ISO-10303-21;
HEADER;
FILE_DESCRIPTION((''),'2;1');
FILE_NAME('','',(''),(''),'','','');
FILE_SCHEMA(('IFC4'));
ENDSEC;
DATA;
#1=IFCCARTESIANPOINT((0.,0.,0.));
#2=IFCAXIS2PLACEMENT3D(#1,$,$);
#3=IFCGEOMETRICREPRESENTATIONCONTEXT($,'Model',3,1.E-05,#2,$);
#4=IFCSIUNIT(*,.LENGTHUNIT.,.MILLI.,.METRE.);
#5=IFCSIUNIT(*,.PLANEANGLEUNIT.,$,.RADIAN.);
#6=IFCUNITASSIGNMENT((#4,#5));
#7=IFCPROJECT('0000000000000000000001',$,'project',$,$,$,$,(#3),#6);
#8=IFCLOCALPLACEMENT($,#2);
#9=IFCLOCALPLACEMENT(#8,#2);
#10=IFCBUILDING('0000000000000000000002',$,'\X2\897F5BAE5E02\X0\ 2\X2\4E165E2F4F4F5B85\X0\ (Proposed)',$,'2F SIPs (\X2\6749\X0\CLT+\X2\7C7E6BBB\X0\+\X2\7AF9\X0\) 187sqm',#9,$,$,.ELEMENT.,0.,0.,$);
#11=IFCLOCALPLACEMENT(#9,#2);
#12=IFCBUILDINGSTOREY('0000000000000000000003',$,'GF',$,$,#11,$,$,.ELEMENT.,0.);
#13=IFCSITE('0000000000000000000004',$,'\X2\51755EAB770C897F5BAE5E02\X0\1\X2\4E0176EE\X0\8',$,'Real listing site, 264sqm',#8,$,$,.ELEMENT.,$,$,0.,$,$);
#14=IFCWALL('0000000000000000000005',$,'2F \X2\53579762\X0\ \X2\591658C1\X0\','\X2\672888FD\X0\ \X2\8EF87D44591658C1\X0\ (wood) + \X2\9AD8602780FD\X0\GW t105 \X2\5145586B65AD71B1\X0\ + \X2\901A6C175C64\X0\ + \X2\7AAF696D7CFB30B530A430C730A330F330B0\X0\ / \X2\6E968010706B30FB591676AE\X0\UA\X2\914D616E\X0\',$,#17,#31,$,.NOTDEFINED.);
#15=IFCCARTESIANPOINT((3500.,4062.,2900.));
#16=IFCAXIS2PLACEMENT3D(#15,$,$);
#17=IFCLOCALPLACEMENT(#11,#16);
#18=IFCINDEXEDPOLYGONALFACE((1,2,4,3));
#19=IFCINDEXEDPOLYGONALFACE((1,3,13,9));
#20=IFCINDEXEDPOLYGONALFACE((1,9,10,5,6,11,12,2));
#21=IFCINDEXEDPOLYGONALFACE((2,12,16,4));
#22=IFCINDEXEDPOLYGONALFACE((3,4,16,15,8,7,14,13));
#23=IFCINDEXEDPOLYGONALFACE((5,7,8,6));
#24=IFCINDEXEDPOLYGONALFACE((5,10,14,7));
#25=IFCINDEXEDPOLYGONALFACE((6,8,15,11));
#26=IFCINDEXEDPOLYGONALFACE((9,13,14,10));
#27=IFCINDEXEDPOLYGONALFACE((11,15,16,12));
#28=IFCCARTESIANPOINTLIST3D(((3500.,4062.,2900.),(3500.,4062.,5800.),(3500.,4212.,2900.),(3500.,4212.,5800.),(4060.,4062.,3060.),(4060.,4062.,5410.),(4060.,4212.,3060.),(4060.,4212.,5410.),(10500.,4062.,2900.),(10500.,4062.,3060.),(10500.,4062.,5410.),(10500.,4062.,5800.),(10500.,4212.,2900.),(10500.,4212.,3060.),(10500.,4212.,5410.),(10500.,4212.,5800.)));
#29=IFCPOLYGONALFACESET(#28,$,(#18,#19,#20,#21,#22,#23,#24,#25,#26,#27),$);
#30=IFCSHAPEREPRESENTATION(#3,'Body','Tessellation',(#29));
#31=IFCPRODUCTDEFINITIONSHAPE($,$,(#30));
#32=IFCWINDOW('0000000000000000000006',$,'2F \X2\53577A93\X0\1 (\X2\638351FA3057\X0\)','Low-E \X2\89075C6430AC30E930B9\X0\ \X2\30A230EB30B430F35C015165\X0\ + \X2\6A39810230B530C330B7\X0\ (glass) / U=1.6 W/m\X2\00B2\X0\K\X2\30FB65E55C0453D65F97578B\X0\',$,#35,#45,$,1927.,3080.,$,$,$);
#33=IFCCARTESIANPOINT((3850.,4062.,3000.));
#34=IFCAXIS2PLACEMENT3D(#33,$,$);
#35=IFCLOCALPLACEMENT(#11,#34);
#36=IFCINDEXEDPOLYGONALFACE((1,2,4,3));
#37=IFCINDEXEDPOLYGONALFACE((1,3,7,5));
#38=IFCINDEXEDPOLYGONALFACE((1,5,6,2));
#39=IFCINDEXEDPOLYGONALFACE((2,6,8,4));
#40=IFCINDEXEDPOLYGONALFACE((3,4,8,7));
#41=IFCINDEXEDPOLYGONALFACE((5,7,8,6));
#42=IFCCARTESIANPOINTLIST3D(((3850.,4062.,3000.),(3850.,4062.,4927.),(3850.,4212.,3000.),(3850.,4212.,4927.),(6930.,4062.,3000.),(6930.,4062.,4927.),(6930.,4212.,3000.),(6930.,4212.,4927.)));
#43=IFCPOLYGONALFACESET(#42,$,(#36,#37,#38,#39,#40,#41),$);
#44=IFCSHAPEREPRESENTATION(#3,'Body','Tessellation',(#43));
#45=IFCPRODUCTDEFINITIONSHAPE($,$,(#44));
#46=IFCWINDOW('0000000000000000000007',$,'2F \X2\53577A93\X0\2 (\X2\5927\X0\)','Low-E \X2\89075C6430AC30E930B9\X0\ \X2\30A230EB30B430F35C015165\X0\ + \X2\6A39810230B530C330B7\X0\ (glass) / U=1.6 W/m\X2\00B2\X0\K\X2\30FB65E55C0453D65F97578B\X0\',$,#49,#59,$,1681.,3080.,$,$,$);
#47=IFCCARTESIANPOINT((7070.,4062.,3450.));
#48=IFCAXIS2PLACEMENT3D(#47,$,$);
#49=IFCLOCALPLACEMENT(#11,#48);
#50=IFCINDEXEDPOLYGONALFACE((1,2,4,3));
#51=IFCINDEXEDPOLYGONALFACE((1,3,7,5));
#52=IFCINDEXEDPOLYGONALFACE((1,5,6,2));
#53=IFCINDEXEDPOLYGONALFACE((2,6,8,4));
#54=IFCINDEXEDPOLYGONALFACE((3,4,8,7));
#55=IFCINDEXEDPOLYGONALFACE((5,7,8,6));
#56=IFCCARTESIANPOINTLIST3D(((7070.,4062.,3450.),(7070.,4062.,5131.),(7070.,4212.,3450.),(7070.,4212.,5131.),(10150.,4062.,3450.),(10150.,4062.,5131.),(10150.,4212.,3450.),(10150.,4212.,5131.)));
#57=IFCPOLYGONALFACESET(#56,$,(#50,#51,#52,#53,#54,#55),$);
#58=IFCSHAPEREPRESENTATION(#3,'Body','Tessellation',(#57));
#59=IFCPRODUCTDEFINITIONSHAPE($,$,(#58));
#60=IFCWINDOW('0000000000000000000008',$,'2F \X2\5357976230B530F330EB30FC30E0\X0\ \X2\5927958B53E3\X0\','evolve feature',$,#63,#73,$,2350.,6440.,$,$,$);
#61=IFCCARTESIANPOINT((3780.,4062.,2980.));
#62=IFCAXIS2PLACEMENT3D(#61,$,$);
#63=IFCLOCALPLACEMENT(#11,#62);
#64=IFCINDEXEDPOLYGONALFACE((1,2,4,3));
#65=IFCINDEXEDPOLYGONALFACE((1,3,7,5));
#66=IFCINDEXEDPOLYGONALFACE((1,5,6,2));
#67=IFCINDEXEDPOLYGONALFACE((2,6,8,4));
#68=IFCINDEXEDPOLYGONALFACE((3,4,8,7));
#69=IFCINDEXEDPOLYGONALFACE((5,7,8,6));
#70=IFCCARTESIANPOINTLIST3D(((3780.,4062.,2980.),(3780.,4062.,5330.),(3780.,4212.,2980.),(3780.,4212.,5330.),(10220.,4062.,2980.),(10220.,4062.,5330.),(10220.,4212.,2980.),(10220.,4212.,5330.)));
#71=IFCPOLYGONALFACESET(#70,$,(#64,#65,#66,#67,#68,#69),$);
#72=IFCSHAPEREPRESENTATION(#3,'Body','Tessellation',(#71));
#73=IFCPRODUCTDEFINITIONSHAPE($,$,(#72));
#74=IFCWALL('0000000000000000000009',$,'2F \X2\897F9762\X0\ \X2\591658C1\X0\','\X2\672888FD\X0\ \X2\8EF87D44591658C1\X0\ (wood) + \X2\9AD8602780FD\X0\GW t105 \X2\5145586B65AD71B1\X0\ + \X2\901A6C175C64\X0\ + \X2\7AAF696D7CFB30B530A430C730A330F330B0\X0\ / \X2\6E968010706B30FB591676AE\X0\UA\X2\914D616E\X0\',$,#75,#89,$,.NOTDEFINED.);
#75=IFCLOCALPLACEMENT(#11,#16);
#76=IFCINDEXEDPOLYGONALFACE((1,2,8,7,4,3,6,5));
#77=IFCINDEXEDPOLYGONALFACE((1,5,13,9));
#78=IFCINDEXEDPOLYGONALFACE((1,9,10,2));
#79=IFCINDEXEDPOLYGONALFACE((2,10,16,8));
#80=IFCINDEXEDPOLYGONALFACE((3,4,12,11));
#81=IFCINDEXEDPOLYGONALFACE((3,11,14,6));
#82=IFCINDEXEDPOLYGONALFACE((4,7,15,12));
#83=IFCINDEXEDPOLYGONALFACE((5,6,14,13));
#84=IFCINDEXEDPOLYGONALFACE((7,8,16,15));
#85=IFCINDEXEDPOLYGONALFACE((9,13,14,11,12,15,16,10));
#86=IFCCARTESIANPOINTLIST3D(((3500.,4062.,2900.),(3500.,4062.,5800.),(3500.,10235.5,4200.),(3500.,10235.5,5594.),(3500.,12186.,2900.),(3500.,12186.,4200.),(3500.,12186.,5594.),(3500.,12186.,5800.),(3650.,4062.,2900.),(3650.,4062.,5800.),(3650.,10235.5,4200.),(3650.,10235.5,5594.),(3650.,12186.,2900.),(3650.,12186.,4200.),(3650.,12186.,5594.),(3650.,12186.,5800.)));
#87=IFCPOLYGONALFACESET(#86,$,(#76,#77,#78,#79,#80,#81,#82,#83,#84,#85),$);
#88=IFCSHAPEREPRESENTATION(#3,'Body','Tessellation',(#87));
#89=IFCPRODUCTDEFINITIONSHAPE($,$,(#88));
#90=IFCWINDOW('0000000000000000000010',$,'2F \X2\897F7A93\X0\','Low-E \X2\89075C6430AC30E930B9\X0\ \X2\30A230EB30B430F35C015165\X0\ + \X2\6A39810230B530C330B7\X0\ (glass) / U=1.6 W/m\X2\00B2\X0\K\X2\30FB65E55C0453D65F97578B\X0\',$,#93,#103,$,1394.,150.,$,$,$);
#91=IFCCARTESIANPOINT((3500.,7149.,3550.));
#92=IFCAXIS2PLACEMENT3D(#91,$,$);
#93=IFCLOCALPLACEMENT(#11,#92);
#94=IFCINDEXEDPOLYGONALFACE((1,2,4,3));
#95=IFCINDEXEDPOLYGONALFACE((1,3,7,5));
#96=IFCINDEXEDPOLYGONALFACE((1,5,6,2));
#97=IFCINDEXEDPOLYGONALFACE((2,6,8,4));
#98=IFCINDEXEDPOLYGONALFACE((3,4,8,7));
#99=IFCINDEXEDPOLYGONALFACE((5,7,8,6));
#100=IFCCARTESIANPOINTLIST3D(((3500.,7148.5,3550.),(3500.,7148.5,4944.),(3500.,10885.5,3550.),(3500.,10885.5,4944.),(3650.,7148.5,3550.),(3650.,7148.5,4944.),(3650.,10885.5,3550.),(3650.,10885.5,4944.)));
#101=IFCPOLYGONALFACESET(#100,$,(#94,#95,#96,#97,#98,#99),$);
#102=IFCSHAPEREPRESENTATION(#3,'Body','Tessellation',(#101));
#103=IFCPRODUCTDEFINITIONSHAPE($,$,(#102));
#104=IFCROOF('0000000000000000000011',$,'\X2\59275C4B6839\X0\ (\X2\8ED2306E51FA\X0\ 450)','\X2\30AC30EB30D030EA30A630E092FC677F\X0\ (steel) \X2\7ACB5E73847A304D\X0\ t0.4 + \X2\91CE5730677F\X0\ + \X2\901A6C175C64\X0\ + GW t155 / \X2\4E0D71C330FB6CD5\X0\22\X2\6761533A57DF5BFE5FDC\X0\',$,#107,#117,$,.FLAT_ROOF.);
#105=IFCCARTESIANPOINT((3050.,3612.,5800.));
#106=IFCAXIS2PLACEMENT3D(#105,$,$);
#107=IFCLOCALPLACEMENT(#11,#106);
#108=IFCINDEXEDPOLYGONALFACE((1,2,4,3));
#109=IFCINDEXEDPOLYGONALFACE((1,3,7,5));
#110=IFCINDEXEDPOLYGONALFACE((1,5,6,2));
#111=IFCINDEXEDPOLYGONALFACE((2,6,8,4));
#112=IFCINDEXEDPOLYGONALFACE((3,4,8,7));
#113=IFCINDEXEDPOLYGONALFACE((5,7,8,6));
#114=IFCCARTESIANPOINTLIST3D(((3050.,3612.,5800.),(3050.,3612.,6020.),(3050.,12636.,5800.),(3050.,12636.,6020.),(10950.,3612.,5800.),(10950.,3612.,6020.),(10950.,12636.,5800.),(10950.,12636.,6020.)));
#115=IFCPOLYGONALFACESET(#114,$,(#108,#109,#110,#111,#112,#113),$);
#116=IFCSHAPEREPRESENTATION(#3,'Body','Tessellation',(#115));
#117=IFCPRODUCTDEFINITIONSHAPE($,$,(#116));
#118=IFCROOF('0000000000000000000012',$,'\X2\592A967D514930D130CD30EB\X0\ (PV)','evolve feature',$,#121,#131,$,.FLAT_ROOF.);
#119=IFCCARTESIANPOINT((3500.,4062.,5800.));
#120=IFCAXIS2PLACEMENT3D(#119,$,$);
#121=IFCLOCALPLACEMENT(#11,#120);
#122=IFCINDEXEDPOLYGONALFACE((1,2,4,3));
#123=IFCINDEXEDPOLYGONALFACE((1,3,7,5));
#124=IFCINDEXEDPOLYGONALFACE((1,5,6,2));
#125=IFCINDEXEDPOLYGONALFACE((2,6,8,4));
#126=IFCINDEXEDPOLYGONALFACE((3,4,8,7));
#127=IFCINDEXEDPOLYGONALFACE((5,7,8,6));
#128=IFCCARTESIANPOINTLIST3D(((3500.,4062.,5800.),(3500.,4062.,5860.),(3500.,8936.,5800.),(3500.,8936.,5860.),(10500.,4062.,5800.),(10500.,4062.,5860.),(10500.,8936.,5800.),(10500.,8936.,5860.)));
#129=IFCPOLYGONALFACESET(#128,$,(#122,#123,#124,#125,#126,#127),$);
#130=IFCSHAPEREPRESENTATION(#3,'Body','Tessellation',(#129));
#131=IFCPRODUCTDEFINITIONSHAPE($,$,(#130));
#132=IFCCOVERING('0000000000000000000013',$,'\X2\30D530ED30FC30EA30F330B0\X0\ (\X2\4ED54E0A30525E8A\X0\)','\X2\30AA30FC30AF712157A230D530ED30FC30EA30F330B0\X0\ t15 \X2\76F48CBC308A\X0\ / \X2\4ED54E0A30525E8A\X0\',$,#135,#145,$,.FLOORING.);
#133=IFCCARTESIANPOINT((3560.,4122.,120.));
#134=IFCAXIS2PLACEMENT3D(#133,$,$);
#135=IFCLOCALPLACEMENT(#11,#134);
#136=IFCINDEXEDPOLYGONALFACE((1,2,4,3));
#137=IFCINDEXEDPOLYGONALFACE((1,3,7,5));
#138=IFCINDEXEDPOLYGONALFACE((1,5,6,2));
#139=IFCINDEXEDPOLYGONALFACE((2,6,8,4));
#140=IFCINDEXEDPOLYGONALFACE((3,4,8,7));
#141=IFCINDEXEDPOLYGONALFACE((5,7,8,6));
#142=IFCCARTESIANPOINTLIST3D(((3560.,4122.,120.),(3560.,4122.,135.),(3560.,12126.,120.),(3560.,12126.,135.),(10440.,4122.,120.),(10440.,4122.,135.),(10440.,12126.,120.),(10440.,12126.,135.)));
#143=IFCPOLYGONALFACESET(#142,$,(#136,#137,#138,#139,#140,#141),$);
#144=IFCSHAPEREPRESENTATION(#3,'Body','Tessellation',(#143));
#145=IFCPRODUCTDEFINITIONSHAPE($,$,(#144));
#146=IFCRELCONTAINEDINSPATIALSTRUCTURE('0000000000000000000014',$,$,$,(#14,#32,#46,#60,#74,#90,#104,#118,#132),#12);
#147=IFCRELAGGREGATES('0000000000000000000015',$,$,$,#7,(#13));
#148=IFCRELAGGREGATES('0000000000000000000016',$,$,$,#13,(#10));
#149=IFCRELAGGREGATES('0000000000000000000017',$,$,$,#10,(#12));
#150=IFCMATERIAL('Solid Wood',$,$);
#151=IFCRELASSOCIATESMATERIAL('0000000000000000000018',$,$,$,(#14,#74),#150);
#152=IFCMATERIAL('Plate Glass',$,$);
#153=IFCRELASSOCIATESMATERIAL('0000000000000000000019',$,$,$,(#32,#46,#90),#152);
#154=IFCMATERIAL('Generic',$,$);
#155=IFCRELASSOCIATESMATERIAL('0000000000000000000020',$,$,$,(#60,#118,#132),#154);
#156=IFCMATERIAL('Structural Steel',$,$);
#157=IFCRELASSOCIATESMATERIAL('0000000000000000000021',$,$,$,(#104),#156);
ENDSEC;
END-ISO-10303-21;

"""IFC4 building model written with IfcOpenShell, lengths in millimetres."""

from ifc_helpers import new_model, si_unit, frame, frame_2d, origin, place, context, project, spatial, rectangle, extrude, material, element, fill, save


model = new_model("IFC4")

# Units and contexts
model_context = context("Model", 3, precision=1e-05, world=origin())
ifc_project = project(units=[si_unit("LENGTHUNIT", "METRE", prefix="MILLI"), si_unit("PLANEANGLEUNIT", "RADIAN")], contexts=[model_context])

# Site, building, storey
site_placement = place(None, origin())
site = spatial("IfcSite", under=ifc_project, at=site_placement, Name="兵庫県西宮市1丁目8", ObjectType="Real listing site, 264sqm", CompositionType="ELEMENT", RefElevation=0.0)
building_placement = place(site_placement, origin())
building = spatial("IfcBuilding", under=site, at=building_placement, Name="西宮市 2世帯住宅 (Proposed)", ObjectType="2F SIPs (杉CLT+籾殻+竹) 187sqm", CompositionType="ELEMENT", ElevationOfRefHeight=0.0, ElevationOfTerrain=0.0)
storey_placement = place(building_placement, origin())
storey = spatial("IfcBuildingStorey", under=building, at=storey_placement, Name="GF", CompositionType="ELEMENT", Elevation=0.0)

# Shared definitions
ifc_material_1 = material(Name="Solid Wood")
ifc_material_2 = material(Name="Generic")

# Shared definitions
ifc_material_3 = material(Name="Plate Glass")

# Wall, openings, windows
wall_1_placement = place(storey_placement, frame((3500.0, 4062.0, 2900.0)))
wall_1 = element("IfcWall", 1, at=wall_1_placement, inside=storey, material=ifc_material_1, Name="2F 南面 外壁", Description="木製 軸組外壁 (wood) + 高性能GW t105 充填断熱 + 通気層 + 窯業系サイディング / 準耐火・外皮UA配慮", PredefinedType="NOTDEFINED", context=model_context, shape_type="SweptSolid", body=[
    extrude(rectangle(XDim=7000.0, YDim=150.0, at=frame_2d((3500.0, 75.0))), frame((3500.0, 4062.0, 2900.0)), (0.0, 0.0, 1.0), 2900.0),
])
opening_1_placement = place(storey_placement, frame((3850.0, 4062.0, 3000.0)))
opening_1 = element("IfcOpeningElement", 2, at=opening_1_placement, cuts=wall_1, PredefinedType="NOTDEFINED", context=model_context, shape_type="SweptSolid", body=[
    extrude(rectangle(XDim=3080.0, YDim=150.0, at=frame_2d((1540.0, 75.0))), frame((3850.0, 4062.0, 3000.0)), (0.0, 0.0, 1.0), 1927.0),
])
opening_2_placement = place(storey_placement, frame((7070.0, 4062.0, 3450.0)))
opening_2 = element("IfcOpeningElement", 3, at=opening_2_placement, cuts=wall_1, PredefinedType="NOTDEFINED", context=model_context, shape_type="SweptSolid", body=[
    extrude(rectangle(XDim=3080.0, YDim=150.0, at=frame_2d((1540.0, 75.0))), frame((7070.0, 4062.0, 3450.0)), (0.0, 0.0, 1.0), 1681.0),
])
opening_3_placement = place(storey_placement, frame((3780.0, 4062.0, 2980.0)))
opening_3 = element("IfcOpeningElement", 4, at=opening_3_placement, cuts=wall_1, PredefinedType="NOTDEFINED", context=model_context, shape_type="SweptSolid", body=[
    extrude(rectangle(XDim=6440.0, YDim=150.0, at=frame_2d((3220.0, 75.0))), frame((3780.0, 4062.0, 2980.0)), (0.0, 0.0, 1.0), 2350.0),
])
window_1_placement = place(storey_placement, frame((3850.0, 4062.0, 3000.0)))
window_1 = element("IfcWindow", 5, at=window_1_placement, inside=storey, material=ifc_material_3, Name="2F 南窓1 (掃出し)", Description="Low-E 複層ガラス アルゴン封入 + 樹脂サッシ (glass) / U=1.6 W/m²K・日射取得型", OverallHeight=1927.0, OverallWidth=3080.0, context=model_context, shape_type="SweptSolid", body=[
    extrude(rectangle(XDim=3080.0, YDim=150.0, at=frame_2d((1540.0, 75.0))), frame((3850.0, 4062.0, 3000.0)), (0.0, 0.0, 1.0), 1927.0),
])
fill(opening_1, window_1)
window_2_placement = place(storey_placement, frame((7070.0, 4062.0, 3450.0)))
window_2 = element("IfcWindow", 6, at=window_2_placement, inside=storey, material=ifc_material_3, Name="2F 南窓2 (大)", Description="Low-E 複層ガラス アルゴン封入 + 樹脂サッシ (glass) / U=1.6 W/m²K・日射取得型", OverallHeight=1681.0, OverallWidth=3080.0, context=model_context, shape_type="SweptSolid", body=[
    extrude(rectangle(XDim=3080.0, YDim=150.0, at=frame_2d((1540.0, 75.0))), frame((7070.0, 4062.0, 3450.0)), (0.0, 0.0, 1.0), 1681.0),
])
fill(opening_2, window_2)
window_3_placement = place(storey_placement, frame((3780.0, 4062.0, 2980.0)))
window_3 = element("IfcWindow", 7, at=window_3_placement, inside=storey, material=ifc_material_2, Name="2F 南面サンルーム 大開口", Description="evolve feature", OverallHeight=2350.0, OverallWidth=6440.0, context=model_context, shape_type="SweptSolid", body=[
    extrude(rectangle(XDim=6440.0, YDim=150.0, at=frame_2d((3220.0, 75.0))), frame((3780.0, 4062.0, 2980.0)), (0.0, 0.0, 1.0), 2350.0),
])
fill(opening_3, window_3)

# Wall, opening, window
wall_2_placement = place(storey_placement, frame((3500.0, 4062.0, 2900.0)))
wall_2 = element("IfcWall", 8, at=wall_2_placement, inside=storey, material=ifc_material_1, Name="2F 西面 外壁", Description="木製 軸組外壁 (wood) + 高性能GW t105 充填断熱 + 通気層 + 窯業系サイディング / 準耐火・外皮UA配慮", PredefinedType="NOTDEFINED", context=model_context, shape_type="SweptSolid", body=[
    extrude(rectangle(XDim=150.0, YDim=8124.0, at=frame_2d((75.0, 4062.0))), frame((3500.0, 4062.0, 2900.0)), (0.0, 0.0, 1.0), 2900.0),
])
opening_4_placement = place(storey_placement, frame((3500.0, 7149.0, 3550.0)))
opening_4 = element("IfcOpeningElement", 9, at=opening_4_placement, cuts=wall_2, PredefinedType="NOTDEFINED", context=model_context, shape_type="SweptSolid", body=[
    extrude(rectangle(XDim=150.0, YDim=3737.0, at=frame_2d((75.0, 1868.0))), frame((3500.0, 7149.0, 3550.0)), (0.0, 0.0, 1.0), 1394.0),
])
window_4_placement = place(storey_placement, frame((3500.0, 7149.0, 3550.0)))
window_4 = element("IfcWindow", 10, at=window_4_placement, inside=storey, material=ifc_material_3, Name="2F 西窓", Description="Low-E 複層ガラス アルゴン封入 + 樹脂サッシ (glass) / U=1.6 W/m²K・日射取得型", OverallHeight=1394.0, OverallWidth=150.0, context=model_context, shape_type="SweptSolid", body=[
    extrude(rectangle(XDim=150.0, YDim=3737.0, at=frame_2d((75.0, 1868.0))), frame((3500.0, 7149.0, 3550.0)), (0.0, 0.0, 1.0), 1394.0),
])
fill(opening_4, window_4)

# Roofs
ifc_material_4 = material(Name="Structural Steel")
roof_1_placement = place(storey_placement, frame((3050.0, 3612.0, 5800.0)))
element("IfcRoof", 11, at=roof_1_placement, inside=storey, material=ifc_material_4, Name="大屋根 (軒の出 450)", Description="ガルバリウム鋼板 (steel) 立平葺き t0.4 + 野地板 + 通気層 + GW t155 / 不燃・法22条区域対応", PredefinedType="FLAT_ROOF", context=model_context, shape_type="SweptSolid", body=[
    extrude(rectangle(XDim=7900.0, YDim=9024.0, at=frame_2d((3950.0, 4512.0))), frame((3050.0, 3612.0, 5800.0)), (0.0, 0.0, 1.0), 220.0),
])
roof_2_placement = place(storey_placement, frame((3500.0, 4062.0, 5800.0)))
element("IfcRoof", 12, at=roof_2_placement, inside=storey, material=ifc_material_2, Name="太陽光パネル (PV)", Description="evolve feature", PredefinedType="FLAT_ROOF", context=model_context, shape_type="SweptSolid", body=[
    extrude(rectangle(XDim=7000.0, YDim=4874.0, at=frame_2d((3500.0, 2437.0))), frame((3500.0, 4062.0, 5800.0)), (0.0, 0.0, 1.0), 60.0),
])

# Covering
covering_placement = place(storey_placement, frame((3560.0, 4122.0, 120.0)))
element("IfcCovering", 13, at=covering_placement, inside=storey, material=ifc_material_2, Name="フローリング (仕上げ床)", Description="オーク無垢フローリング t15 直貼り / 仕上げ床", PredefinedType="FLOORING", context=model_context, shape_type="SweptSolid", body=[
    extrude(rectangle(XDim=6880.0, YDim=8004.0, at=frame_2d((3440.0, 4002.0))), frame((3560.0, 4122.0, 120.0)), (0.0, 0.0, 1.0), 15.0),
])

save(model, "model.ifc")
